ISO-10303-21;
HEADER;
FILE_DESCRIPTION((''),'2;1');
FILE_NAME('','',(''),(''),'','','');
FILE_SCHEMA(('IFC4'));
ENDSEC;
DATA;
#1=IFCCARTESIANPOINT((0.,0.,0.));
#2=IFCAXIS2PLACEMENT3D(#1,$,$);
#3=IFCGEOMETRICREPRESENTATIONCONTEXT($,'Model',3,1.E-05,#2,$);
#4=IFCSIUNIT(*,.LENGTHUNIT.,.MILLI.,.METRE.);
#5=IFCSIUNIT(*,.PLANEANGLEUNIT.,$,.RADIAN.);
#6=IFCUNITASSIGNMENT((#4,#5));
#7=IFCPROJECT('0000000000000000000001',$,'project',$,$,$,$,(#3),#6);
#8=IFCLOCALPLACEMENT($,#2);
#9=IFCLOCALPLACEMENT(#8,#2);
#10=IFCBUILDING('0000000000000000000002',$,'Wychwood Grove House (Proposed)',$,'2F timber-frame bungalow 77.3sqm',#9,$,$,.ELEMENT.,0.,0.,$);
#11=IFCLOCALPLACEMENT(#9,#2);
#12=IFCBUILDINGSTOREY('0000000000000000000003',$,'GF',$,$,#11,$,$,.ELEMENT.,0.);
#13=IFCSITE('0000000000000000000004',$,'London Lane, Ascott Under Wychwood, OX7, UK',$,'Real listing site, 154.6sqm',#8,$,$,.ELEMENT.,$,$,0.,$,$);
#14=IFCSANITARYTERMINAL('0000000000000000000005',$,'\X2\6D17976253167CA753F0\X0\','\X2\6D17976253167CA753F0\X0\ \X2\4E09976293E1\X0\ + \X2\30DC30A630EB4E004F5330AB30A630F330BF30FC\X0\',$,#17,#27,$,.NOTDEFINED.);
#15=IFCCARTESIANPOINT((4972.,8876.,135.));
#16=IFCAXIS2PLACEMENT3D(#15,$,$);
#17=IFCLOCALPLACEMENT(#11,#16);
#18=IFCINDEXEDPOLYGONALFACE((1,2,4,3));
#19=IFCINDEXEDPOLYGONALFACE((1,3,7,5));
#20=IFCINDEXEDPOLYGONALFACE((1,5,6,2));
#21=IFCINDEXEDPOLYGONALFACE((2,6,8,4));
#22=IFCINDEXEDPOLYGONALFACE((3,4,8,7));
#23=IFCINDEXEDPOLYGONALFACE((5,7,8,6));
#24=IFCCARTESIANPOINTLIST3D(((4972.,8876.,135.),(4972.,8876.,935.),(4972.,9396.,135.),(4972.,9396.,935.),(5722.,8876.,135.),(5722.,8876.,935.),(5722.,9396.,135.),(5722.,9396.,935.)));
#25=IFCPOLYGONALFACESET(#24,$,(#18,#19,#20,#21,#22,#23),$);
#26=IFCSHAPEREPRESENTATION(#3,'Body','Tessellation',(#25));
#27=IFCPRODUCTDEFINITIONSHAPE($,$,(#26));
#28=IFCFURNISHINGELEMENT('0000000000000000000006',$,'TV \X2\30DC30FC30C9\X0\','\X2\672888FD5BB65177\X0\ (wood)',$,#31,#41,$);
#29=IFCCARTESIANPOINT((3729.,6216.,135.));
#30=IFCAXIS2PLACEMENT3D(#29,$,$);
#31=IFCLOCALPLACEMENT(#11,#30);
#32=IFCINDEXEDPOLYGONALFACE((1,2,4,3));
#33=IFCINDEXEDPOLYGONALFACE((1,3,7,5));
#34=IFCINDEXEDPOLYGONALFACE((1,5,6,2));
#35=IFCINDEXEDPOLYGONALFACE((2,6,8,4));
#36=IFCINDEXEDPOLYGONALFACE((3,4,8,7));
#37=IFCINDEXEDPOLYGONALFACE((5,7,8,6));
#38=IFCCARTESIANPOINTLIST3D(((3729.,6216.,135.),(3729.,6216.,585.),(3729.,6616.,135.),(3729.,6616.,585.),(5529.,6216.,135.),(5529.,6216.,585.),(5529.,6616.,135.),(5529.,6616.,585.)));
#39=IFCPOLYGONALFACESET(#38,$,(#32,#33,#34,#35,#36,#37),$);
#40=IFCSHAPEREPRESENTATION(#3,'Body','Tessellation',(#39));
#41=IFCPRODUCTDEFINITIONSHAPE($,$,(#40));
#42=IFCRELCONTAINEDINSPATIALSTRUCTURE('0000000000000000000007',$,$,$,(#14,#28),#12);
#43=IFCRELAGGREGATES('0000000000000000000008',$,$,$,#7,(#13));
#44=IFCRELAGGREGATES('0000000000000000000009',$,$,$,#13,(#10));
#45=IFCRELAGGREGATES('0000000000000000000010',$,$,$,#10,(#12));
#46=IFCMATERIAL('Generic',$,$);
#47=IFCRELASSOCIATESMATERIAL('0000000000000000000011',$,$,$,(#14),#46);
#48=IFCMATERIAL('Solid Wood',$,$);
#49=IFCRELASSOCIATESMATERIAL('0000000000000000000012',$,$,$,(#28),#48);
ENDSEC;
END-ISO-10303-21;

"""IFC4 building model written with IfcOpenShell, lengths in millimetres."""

from ifc_helpers import new_model, si_unit, frame, frame_2d, origin, place, context, project, spatial, rectangle, extrude, material, element, save


model = new_model("IFC4")

# Units and contexts
model_context = context("Model", 3, precision=1e-05, world=origin())
ifc_project = project(units=[si_unit("LENGTHUNIT", "METRE", prefix="MILLI"), si_unit("PLANEANGLEUNIT", "RADIAN")], contexts=[model_context])

# Site, building, storey
site_placement = place(None, origin())
site = spatial("IfcSite", under=ifc_project, at=site_placement, Name="London Lane, Ascott Under Wychwood, OX7, UK", ObjectType="Real listing site, 154.6sqm", CompositionType="ELEMENT", RefElevation=0.0)
building_placement = place(site_placement, origin())
building = spatial("IfcBuilding", under=site, at=building_placement, Name="Wychwood Grove House (Proposed)", ObjectType="2F timber-frame bungalow 77.3sqm", CompositionType="ELEMENT", ElevationOfRefHeight=0.0, ElevationOfTerrain=0.0)
storey_placement = place(building_placement, origin())
storey = spatial("IfcBuildingStorey", under=building, at=storey_placement, Name="GF", CompositionType="ELEMENT", Elevation=0.0)

# Shared definitions
ifc_material_1 = material(Name="Solid Wood")

# Shared definitions
ifc_material_2 = material(Name="Generic")

# Sanitary terminal
sanitary_terminal_1_placement = place(storey_placement, frame((4972.0, 8876.0, 135.0)))
element("IfcSanitaryTerminal", 1, at=sanitary_terminal_1_placement, inside=storey, material=ifc_material_2, Name="洗面化粧台", Description="洗面化粧台 三面鏡 + ボウル一体カウンター", PredefinedType="NOTDEFINED", context=model_context, shape_type="SweptSolid", body=[
    extrude(rectangle(XDim=750.0, YDim=520.0, at=frame_2d((375.0, 260.0))), frame((4972.0, 8876.0, 135.0)), (0.0, 0.0, 1.0), 800.0),
])

# Furnishing element
furnishing_placement = place(storey_placement, frame((3729.0, 6216.0, 135.0)))
element("IfcFurnishingElement", 2, at=furnishing_placement, inside=storey, material=ifc_material_1, Name="TV ボード", Description="木製家具 (wood)", context=model_context, shape_type="SweptSolid", body=[
    extrude(rectangle(XDim=1800.0, YDim=400.0, at=frame_2d((900.0, 200.0))), frame((3729.0, 6216.0, 135.0)), (0.0, 0.0, 1.0), 450.0),
])

save(model, "model.ifc")
